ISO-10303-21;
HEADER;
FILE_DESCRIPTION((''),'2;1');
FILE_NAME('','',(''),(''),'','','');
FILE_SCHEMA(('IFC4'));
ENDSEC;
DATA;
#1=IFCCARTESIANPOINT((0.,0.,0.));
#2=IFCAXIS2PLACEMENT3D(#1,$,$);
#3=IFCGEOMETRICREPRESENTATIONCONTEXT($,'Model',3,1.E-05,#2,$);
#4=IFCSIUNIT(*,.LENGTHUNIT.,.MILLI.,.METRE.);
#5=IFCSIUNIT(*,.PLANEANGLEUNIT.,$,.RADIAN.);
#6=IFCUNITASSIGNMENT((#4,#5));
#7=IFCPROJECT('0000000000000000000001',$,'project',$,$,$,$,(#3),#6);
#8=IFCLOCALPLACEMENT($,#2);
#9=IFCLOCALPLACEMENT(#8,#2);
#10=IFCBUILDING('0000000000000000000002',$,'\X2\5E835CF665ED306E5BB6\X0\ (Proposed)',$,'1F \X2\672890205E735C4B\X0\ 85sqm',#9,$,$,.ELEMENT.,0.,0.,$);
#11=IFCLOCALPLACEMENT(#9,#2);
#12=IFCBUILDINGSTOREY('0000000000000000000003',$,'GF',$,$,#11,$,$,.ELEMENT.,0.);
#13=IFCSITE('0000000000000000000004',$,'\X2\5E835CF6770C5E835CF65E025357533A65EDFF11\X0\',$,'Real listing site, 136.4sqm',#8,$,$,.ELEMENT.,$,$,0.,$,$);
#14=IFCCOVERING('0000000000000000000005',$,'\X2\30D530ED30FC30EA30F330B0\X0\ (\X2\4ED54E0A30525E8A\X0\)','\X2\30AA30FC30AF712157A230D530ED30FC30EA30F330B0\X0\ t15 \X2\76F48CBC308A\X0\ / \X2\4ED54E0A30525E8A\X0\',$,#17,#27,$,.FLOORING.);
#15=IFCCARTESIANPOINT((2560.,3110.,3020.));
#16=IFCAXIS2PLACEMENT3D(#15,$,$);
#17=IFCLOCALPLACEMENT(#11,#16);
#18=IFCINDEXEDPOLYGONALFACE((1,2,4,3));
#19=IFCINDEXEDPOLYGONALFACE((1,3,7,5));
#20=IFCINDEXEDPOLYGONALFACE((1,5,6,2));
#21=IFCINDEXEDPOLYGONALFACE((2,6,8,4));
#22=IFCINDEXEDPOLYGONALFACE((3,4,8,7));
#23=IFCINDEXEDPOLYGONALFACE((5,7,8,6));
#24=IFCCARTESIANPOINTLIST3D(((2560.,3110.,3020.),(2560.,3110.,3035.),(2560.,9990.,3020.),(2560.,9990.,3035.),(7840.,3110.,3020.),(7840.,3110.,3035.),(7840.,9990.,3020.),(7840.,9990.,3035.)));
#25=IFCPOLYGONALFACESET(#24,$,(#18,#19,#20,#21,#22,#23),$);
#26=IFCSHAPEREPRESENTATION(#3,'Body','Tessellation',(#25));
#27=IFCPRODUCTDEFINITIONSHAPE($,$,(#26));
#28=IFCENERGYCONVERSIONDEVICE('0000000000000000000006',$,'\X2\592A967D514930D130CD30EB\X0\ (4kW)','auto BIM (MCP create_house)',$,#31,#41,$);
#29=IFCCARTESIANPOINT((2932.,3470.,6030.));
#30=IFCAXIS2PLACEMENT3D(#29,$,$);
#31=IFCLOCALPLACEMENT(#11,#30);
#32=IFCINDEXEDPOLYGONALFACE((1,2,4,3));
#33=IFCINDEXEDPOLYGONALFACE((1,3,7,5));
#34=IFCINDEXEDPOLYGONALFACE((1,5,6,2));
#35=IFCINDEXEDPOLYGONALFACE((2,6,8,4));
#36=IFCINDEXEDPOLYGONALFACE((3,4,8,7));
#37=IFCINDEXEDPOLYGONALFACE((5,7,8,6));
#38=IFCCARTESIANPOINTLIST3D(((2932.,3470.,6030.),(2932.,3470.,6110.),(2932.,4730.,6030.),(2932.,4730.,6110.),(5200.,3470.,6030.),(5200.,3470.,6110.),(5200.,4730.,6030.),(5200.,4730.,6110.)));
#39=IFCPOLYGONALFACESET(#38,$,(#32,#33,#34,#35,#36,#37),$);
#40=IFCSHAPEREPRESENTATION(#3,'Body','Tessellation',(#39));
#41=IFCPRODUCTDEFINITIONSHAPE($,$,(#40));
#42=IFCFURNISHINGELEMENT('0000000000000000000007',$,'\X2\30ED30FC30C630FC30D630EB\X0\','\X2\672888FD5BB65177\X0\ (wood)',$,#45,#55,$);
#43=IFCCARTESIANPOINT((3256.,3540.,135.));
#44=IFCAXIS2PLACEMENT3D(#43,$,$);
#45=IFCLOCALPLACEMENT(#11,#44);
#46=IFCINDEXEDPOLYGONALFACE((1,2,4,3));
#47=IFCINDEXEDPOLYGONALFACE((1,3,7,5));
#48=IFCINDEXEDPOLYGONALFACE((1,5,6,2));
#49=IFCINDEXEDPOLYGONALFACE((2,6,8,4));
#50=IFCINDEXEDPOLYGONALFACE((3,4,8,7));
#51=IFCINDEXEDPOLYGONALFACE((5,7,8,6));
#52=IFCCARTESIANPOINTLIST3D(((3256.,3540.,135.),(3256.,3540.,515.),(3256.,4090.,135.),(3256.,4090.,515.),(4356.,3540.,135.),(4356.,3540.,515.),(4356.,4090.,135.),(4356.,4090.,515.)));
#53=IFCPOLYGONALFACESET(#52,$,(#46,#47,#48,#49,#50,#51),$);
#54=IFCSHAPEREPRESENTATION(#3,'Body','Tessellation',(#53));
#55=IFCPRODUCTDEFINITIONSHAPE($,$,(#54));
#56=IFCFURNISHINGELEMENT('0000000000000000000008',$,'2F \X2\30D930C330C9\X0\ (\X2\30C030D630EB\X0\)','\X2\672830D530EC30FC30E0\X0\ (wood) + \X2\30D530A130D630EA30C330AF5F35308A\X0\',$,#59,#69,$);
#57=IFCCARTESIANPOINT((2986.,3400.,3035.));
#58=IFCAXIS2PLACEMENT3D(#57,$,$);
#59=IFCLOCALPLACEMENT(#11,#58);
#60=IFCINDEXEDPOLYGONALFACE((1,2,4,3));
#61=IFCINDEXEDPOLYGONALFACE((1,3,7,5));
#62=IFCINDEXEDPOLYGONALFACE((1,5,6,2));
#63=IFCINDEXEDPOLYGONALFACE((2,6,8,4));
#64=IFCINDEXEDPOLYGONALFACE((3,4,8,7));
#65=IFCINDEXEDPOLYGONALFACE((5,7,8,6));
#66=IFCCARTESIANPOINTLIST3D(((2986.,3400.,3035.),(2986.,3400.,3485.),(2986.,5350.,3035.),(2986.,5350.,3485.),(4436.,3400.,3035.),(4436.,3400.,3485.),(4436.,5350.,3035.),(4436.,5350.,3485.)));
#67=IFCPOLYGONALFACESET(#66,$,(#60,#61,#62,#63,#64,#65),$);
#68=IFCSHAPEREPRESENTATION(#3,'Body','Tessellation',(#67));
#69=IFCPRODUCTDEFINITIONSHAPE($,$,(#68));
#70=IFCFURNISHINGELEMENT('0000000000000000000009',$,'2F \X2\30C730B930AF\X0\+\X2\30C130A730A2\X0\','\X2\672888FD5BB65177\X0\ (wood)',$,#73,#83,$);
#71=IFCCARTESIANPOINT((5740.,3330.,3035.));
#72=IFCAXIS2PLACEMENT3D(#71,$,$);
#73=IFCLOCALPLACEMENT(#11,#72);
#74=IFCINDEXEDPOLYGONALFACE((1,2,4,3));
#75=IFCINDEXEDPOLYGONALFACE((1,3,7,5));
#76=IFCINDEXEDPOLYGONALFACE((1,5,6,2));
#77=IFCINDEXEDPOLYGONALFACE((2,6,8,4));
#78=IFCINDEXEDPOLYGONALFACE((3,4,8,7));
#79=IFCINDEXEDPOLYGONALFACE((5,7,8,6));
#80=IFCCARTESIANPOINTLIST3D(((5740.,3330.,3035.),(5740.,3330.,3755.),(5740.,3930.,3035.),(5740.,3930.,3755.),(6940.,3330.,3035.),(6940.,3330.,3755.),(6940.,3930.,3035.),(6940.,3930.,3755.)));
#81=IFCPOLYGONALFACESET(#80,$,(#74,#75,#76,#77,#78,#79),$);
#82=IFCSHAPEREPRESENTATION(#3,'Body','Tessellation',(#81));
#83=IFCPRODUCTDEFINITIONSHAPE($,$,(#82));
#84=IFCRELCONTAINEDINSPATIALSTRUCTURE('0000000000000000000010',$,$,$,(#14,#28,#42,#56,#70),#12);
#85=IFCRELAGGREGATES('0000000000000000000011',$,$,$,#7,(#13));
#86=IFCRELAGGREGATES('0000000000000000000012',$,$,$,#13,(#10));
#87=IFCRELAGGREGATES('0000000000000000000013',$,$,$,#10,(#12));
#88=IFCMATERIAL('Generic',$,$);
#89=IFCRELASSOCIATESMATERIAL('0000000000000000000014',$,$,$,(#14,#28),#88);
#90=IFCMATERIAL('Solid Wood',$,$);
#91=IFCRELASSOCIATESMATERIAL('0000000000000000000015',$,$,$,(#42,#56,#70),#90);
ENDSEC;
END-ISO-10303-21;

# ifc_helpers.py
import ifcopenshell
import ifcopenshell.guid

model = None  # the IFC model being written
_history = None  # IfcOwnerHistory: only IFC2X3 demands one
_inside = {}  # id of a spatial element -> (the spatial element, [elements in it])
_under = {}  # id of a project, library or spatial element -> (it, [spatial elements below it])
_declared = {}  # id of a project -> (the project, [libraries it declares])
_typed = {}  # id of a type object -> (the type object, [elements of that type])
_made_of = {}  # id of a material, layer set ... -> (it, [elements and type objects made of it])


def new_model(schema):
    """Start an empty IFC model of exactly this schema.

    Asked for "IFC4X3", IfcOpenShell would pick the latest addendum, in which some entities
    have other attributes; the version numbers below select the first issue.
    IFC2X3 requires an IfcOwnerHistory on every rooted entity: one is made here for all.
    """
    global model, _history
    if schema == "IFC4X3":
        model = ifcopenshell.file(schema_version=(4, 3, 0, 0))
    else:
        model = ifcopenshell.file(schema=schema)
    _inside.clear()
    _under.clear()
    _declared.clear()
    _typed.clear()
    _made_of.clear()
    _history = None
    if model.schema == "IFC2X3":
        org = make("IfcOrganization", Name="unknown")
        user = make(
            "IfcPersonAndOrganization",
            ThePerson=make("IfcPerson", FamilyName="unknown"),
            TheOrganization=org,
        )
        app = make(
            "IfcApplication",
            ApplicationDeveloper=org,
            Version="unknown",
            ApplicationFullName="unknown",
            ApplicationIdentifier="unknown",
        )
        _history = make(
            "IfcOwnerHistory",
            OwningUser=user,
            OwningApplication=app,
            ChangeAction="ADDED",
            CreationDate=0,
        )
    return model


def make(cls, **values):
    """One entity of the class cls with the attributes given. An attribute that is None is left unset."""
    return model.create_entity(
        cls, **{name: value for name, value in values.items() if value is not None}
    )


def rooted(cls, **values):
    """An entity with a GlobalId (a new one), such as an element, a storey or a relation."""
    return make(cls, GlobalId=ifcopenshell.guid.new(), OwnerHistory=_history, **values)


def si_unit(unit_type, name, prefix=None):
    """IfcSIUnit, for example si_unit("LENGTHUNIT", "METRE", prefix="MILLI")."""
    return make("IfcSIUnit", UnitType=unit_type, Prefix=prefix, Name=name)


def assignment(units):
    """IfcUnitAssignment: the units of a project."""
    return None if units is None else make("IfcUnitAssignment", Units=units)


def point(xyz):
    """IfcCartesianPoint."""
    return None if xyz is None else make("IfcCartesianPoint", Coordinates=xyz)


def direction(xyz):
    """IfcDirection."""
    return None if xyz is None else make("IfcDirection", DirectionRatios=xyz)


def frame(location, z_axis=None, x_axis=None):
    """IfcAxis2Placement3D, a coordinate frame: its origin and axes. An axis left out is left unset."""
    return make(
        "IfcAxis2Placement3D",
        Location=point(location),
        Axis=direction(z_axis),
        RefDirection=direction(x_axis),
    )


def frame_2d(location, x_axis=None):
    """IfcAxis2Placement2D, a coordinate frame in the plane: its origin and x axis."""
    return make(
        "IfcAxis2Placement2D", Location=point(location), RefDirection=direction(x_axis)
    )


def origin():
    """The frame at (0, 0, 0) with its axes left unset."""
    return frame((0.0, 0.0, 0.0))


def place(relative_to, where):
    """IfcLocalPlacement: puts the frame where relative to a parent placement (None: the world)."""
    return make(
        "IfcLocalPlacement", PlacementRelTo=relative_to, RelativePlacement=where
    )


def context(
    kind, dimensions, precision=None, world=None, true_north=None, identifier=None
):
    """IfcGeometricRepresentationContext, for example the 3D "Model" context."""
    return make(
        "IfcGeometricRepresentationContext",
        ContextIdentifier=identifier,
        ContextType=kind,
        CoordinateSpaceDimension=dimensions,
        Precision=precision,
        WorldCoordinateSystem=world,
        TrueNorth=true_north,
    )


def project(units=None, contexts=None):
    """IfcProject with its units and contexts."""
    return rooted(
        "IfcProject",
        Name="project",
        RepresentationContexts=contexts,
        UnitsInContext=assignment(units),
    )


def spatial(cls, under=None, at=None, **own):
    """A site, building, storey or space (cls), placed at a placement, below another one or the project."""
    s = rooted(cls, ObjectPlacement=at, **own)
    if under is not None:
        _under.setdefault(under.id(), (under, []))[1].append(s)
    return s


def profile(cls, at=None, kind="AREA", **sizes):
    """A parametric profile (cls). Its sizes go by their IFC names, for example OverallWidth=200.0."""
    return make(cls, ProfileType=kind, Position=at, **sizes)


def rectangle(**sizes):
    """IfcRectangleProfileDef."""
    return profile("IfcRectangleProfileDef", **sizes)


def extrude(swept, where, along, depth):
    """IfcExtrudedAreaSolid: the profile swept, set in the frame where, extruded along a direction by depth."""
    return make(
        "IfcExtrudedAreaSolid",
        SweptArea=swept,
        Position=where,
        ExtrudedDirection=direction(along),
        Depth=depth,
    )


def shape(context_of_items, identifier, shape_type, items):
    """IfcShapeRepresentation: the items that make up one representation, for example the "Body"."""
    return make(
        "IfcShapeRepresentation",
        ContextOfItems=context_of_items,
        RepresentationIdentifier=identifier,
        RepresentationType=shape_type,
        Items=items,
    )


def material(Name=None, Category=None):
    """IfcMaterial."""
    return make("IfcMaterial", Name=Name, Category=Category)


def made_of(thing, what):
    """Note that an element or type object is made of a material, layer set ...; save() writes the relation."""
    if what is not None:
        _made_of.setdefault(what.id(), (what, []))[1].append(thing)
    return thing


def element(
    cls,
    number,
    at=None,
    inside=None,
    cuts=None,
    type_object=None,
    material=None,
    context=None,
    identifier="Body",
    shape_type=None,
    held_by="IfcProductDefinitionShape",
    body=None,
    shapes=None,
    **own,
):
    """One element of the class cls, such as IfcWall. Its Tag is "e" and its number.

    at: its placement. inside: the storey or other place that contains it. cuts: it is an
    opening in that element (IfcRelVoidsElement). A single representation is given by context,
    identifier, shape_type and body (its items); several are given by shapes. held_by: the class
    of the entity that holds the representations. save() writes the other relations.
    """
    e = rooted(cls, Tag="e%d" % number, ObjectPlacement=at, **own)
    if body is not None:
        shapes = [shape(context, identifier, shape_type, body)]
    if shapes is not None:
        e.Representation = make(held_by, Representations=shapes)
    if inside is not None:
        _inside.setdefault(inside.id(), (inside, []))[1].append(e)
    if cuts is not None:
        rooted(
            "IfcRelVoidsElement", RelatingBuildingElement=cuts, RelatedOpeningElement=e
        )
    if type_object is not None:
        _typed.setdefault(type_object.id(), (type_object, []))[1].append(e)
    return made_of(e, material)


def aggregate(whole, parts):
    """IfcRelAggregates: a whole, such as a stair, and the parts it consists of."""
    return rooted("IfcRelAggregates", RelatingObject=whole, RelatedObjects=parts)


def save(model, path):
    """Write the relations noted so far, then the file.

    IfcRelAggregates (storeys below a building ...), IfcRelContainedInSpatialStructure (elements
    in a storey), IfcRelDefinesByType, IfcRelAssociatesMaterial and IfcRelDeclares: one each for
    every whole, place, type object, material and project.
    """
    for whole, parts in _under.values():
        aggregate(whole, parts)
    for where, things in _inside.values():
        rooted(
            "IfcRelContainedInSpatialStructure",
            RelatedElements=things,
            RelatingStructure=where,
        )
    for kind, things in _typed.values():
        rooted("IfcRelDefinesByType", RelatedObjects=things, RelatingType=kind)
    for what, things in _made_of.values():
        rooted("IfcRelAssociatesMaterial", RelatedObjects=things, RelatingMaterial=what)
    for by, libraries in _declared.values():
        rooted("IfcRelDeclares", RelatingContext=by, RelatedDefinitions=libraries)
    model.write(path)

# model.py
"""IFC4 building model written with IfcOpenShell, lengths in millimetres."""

from ifc_helpers import new_model, si_unit, frame, frame_2d, origin, place, context, project, spatial, rectangle, extrude, material, element, save


model = new_model("IFC4")

# Units and contexts
model_context = context("Model", 3, precision=1e-05, world=origin())
ifc_project = project(units=[si_unit("LENGTHUNIT", "METRE", prefix="MILLI"), si_unit("PLANEANGLEUNIT", "RADIAN")], contexts=[model_context])

# Site, building, storey
site_placement = place(None, origin())
site = spatial("IfcSite", under=ifc_project, at=site_placement, Name="広島県広島市南区旭１", ObjectType="Real listing site, 136.4sqm", CompositionType="ELEMENT", RefElevation=0.0)
building_placement = place(site_placement, origin())
building = spatial("IfcBuilding", under=site, at=building_placement, Name="広島旭の家 (Proposed)", ObjectType="1F 木造平屋 85sqm", CompositionType="ELEMENT", ElevationOfRefHeight=0.0, ElevationOfTerrain=0.0)
storey_placement = place(building_placement, origin())
storey = spatial("IfcBuildingStorey", under=building, at=storey_placement, Name="GF", CompositionType="ELEMENT", Elevation=0.0)

# Shared definitions
ifc_material_1 = material(Name="Solid Wood")

# Shared definitions
ifc_material_2 = material(Name="Generic")

# Covering
covering_placement = place(storey_placement, frame((2560.0, 3110.0, 3020.0)))
element("IfcCovering", 1, at=covering_placement, inside=storey, material=ifc_material_2, Name="フローリング (仕上げ床)", Description="オーク無垢フローリング t15 直貼り / 仕上げ床", PredefinedType="FLOORING", context=model_context, shape_type="SweptSolid", body=[
    extrude(rectangle(XDim=5280.0, YDim=6880.0, at=frame_2d((2640.0, 3440.0))), frame((2560.0, 3110.0, 3020.0)), (0.0, 0.0, 1.0), 15.0),
])

# Energy conversion device
energy_conversion_device_placement = place(storey_placement, frame((2932.0, 3470.0, 6030.0)))
element("IfcEnergyConversionDevice", 2, at=energy_conversion_device_placement, inside=storey, material=ifc_material_2, Name="太陽光パネル (4kW)", Description="auto BIM (MCP create_house)", context=model_context, shape_type="SweptSolid", body=[
    extrude(rectangle(XDim=2268.0, YDim=1260.0, at=frame_2d((1134.0, 630.0))), frame((2932.0, 3470.0, 6030.0)), (0.0, 0.0, 1.0), 80.0),
])

# Furnishing elements
furnishing_1_placement = place(storey_placement, frame((3256.0, 3540.0, 135.0)))
element("IfcFurnishingElement", 3, at=furnishing_1_placement, inside=storey, material=ifc_material_1, Name="ローテーブル", Description="木製家具 (wood)", context=model_context, shape_type="SweptSolid", body=[
    extrude(rectangle(XDim=1100.0, YDim=550.0, at=frame_2d((550.0, 275.0))), frame((3256.0, 3540.0, 135.0)), (0.0, 0.0, 1.0), 380.0),
])
furnishing_2_placement = place(storey_placement, frame((2986.0, 3400.0, 3035.0)))
element("IfcFurnishingElement", 4, at=furnishing_2_placement, inside=storey, material=ifc_material_1, Name="2F ベッド (ダブル)", Description="木フレーム (wood) + ファブリック張り", context=model_context, shape_type="SweptSolid", body=[
    extrude(rectangle(XDim=1450.0, YDim=1950.0, at=frame_2d((725.0, 975.0))), frame((2986.0, 3400.0, 3035.0)), (0.0, 0.0, 1.0), 450.0),
])
furnishing_3_placement = place(storey_placement, frame((5740.0, 3330.0, 3035.0)))
element("IfcFurnishingElement", 5, at=furnishing_3_placement, inside=storey, material=ifc_material_1, Name="2F デスク+チェア", Description="木製家具 (wood)", context=model_context, shape_type="SweptSolid", body=[
    extrude(rectangle(XDim=1200.0, YDim=600.0, at=frame_2d((600.0, 300.0))), frame((5740.0, 3330.0, 3035.0)), (0.0, 0.0, 1.0), 720.0),
])

save(model, "model.ifc")
